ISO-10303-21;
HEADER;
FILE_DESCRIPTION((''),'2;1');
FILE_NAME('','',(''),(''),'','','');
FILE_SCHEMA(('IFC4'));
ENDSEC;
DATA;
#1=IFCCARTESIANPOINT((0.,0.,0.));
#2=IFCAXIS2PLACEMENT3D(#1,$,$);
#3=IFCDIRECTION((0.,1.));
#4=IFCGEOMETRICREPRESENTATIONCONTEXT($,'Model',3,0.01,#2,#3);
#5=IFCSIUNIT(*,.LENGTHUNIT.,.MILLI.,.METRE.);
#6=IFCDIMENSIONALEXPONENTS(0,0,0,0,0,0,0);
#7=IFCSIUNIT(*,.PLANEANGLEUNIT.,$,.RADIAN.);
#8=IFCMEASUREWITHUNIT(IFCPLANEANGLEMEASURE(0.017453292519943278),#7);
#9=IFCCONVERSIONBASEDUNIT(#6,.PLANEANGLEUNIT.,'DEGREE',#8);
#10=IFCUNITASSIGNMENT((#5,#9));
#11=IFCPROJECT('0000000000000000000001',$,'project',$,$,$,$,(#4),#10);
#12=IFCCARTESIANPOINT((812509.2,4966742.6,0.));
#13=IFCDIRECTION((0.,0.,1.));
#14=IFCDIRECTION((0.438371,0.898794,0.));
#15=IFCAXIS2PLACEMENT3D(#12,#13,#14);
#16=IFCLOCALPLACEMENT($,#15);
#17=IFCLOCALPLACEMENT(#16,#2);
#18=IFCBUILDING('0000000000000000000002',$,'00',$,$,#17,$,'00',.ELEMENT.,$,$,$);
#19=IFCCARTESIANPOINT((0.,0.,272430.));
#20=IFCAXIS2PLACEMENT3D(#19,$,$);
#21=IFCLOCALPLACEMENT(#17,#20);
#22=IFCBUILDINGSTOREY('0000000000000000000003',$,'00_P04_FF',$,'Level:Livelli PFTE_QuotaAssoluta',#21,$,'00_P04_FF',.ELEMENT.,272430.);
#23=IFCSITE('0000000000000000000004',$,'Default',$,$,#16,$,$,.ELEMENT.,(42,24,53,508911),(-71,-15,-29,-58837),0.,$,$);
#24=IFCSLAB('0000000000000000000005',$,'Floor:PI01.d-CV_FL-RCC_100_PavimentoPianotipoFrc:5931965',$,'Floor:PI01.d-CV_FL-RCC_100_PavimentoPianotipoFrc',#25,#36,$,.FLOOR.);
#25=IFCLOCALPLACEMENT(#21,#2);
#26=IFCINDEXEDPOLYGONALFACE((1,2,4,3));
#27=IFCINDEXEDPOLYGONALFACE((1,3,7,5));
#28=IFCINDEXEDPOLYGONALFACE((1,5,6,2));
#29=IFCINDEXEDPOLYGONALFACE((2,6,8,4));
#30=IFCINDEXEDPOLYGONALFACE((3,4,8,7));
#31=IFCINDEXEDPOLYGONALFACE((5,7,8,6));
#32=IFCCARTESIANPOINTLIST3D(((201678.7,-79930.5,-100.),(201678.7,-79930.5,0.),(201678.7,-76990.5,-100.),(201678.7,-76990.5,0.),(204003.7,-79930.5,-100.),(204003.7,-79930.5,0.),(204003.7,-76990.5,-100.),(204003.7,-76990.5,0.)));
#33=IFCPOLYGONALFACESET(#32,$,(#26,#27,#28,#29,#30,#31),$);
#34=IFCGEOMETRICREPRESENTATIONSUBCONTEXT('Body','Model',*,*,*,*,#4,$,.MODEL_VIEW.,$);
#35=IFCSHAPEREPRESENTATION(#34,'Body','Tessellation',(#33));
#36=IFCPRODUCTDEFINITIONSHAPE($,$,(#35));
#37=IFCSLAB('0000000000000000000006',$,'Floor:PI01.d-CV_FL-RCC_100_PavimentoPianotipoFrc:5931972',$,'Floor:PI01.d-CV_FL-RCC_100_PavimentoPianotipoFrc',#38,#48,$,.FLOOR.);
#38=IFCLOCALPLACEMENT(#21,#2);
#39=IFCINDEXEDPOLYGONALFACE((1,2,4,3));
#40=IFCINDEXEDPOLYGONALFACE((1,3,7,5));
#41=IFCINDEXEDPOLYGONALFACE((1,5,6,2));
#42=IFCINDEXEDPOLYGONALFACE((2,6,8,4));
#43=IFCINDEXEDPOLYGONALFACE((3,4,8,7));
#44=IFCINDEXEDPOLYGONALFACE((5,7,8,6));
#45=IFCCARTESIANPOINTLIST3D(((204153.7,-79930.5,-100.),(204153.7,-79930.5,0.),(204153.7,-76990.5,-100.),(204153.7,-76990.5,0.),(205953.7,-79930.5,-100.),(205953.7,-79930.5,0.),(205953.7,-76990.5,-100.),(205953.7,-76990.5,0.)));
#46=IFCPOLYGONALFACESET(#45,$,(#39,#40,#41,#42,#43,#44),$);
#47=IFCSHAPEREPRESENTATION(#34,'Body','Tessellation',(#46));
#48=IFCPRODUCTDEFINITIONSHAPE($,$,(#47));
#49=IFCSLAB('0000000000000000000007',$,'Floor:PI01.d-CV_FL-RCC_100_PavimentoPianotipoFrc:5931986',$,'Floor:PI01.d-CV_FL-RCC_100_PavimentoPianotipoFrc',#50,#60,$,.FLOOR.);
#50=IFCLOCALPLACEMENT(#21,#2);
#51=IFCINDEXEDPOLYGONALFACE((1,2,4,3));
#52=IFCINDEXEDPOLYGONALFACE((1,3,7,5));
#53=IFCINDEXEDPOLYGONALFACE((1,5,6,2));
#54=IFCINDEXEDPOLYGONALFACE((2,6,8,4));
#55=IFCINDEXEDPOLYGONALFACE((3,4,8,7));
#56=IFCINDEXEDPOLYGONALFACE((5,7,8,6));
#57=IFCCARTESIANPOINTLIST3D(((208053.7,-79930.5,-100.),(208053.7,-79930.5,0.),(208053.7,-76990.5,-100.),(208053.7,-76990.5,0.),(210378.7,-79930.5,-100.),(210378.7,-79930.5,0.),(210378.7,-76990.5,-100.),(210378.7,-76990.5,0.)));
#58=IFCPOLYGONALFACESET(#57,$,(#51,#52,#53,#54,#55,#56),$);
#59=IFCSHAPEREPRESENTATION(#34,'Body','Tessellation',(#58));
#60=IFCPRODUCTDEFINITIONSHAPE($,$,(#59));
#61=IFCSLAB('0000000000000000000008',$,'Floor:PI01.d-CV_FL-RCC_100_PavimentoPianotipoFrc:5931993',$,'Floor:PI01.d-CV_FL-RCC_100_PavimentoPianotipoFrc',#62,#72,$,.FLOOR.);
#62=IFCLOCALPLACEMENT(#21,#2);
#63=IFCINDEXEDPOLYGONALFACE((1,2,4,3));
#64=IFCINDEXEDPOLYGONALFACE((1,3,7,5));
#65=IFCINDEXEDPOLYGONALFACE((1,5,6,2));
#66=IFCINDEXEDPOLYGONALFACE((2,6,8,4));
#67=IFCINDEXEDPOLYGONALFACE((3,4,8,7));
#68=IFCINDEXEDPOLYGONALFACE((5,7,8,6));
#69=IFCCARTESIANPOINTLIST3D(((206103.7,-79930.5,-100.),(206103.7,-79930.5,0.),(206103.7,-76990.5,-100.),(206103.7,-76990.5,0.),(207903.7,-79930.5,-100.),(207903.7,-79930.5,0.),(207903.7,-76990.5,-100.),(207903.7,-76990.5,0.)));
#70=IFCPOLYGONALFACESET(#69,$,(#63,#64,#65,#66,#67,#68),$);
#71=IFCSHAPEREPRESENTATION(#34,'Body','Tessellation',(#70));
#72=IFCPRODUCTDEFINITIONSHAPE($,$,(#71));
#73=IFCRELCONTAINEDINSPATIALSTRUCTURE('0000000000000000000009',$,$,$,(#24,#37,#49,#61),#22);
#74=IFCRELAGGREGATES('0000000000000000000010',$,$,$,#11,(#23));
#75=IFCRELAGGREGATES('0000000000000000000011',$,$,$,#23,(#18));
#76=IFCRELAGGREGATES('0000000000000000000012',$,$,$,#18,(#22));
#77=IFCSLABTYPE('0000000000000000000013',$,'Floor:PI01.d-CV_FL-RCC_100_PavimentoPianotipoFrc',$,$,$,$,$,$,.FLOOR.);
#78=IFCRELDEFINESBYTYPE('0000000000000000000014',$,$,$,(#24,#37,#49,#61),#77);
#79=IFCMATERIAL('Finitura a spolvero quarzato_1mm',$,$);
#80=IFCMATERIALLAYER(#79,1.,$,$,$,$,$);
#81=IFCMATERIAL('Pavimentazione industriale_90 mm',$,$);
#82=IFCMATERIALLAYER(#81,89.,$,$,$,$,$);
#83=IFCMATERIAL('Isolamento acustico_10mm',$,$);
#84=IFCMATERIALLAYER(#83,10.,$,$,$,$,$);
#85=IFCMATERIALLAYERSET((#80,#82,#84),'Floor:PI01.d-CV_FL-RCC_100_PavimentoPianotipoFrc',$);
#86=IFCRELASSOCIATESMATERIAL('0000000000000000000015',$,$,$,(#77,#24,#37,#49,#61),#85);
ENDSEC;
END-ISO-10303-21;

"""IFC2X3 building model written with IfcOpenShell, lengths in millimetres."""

from ifc_helpers import new_model, entity, si_unit, converted_unit, direction, frame, frame_2d, origin, place, context, subcontext, project, spatial, rectangle, extrude, material, layer, layer_set, layer_usage, type_object, element, save


model = new_model("IFC2X3")

# Units and contexts
model_context = context("Model", 3, precision=0.01, world=origin(), true_north=direction((0.0, 1.0)))
body_context = subcontext(model_context, "Body", "Model", "MODEL_VIEW")
ifc_project = project(units=[si_unit("LENGTHUNIT", "METRE", prefix="MILLI"), converted_unit("PLANEANGLEUNIT", "DEGREE", entity("IfcPlaneAngleMeasure", 0.017453292519943278), si_unit("PLANEANGLEUNIT", "RADIAN"), dimensions=[0, 0, 0, 0, 0, 0, 0])], contexts=[model_context])

# Site, building, storey
site_placement = place(None, frame((812509.2, 4966742.6, 0.0), z_axis=(0.0, 0.0, 1.0), x_axis=(0.438371, 0.898794, 0.0)))
site = spatial("IfcSite", under=ifc_project, at=site_placement, Name="Default", CompositionType="ELEMENT", RefLatitude=(42, 24, 53, 508911), RefLongitude=(-71, -15, -29, -58837), RefElevation=0.0)
building_placement = place(site_placement, origin())
building = spatial("IfcBuilding", under=site, at=building_placement, Name="00", LongName="00", CompositionType="ELEMENT")
storey_placement = place(building_placement, frame((0.0, 0.0, 272430.0)))
storey = spatial("IfcBuildingStorey", under=building, at=storey_placement, Name="00_P04_FF", ObjectType="Level:Livelli PFTE_QuotaAssoluta", LongName="00_P04_FF", CompositionType="ELEMENT", Elevation=272430.0)

# Slabs
ifc_material_1 = material(Name="Isolamento acustico_10mm")
ifc_material_2 = material(Name="Finitura a spolvero quarzato_1mm")
ifc_layer_1 = layer(ifc_material_2, 1.0)
ifc_material_3 = material(Name="Pavimentazione industriale_90 mm")
ifc_layer_2 = layer(ifc_material_3, 89.0)
ifc_layer_3 = layer(ifc_material_1, 10.0)
ifc_layer_set_1 = layer_set([ifc_layer_1, ifc_layer_2, ifc_layer_3], Name="Floor:PI01.d-CV_FL-RCC_100_PavimentoPianotipoFrc")
ifc_layer_usage_1 = layer_usage(ifc_layer_set_1, "AXIS3", "POSITIVE", 0.0)
slab_type_1 = type_object("IfcSlabType", Name="Floor:PI01.d-CV_FL-RCC_100_PavimentoPianotipoFrc", PredefinedType="FLOOR", material=ifc_layer_set_1)
slab_1_placement = place(storey_placement, origin())
element("IfcSlab", 1, at=slab_1_placement, inside=storey, type_object=slab_type_1, material=ifc_layer_usage_1, Name="Floor:PI01.d-CV_FL-RCC_100_PavimentoPianotipoFrc:5931965", ObjectType="Floor:PI01.d-CV_FL-RCC_100_PavimentoPianotipoFrc", PredefinedType="FLOOR", context=body_context, shape_type="SweptSolid", body=[
    extrude(rectangle(XDim=2940.0, YDim=2325.0, at=frame_2d((0.0, 0.0), x_axis=(1.0, 0.0))), frame((202841.2, -78460.5, 0.0), z_axis=(0.0, 0.0, -1.0), x_axis=(0.0, 1.0, 0.0)), (0.0, 0.0, 1.0), 100.0),
])
ifc_layer_usage_2 = layer_usage(ifc_layer_set_1, "AXIS3", "POSITIVE", 0.0)
slab_2_placement = place(storey_placement, origin())
element("IfcSlab", 2, at=slab_2_placement, inside=storey, type_object=slab_type_1, material=ifc_layer_usage_2, Name="Floor:PI01.d-CV_FL-RCC_100_PavimentoPianotipoFrc:5931972", ObjectType="Floor:PI01.d-CV_FL-RCC_100_PavimentoPianotipoFrc", PredefinedType="FLOOR", context=body_context, shape_type="SweptSolid", body=[
    extrude(rectangle(XDim=2940.0, YDim=1800.0, at=frame_2d((0.0, 0.0), x_axis=(1.0, 0.0))), frame((205053.7, -78460.5, 0.0), z_axis=(0.0, 0.0, -1.0), x_axis=(0.0, 1.0, 0.0)), (0.0, 0.0, 1.0), 100.0),
])
ifc_layer_usage_3 = layer_usage(ifc_layer_set_1, "AXIS3", "POSITIVE", 0.0)
slab_3_placement = place(storey_placement, origin())
element("IfcSlab", 3, at=slab_3_placement, inside=storey, type_object=slab_type_1, material=ifc_layer_usage_3, Name="Floor:PI01.d-CV_FL-RCC_100_PavimentoPianotipoFrc:5931986", ObjectType="Floor:PI01.d-CV_FL-RCC_100_PavimentoPianotipoFrc", PredefinedType="FLOOR", context=body_context, shape_type="SweptSolid", body=[
    extrude(rectangle(XDim=2940.0, YDim=2325.0, at=frame_2d((0.0, 0.0), x_axis=(1.0, 0.0))), frame((209216.2, -78460.5, 0.0), z_axis=(0.0, 0.0, -1.0), x_axis=(0.0, 1.0, 0.0)), (0.0, 0.0, 1.0), 100.0),
])
ifc_layer_usage_4 = layer_usage(ifc_layer_set_1, "AXIS3", "POSITIVE", 0.0)
slab_4_placement = place(storey_placement, origin())
element("IfcSlab", 4, at=slab_4_placement, inside=storey, type_object=slab_type_1, material=ifc_layer_usage_4, Name="Floor:PI01.d-CV_FL-RCC_100_PavimentoPianotipoFrc:5931993", ObjectType="Floor:PI01.d-CV_FL-RCC_100_PavimentoPianotipoFrc", PredefinedType="FLOOR", context=body_context, shape_type="SweptSolid", body=[
    extrude(rectangle(XDim=2940.0, YDim=1800.0, at=frame_2d((0.0, 0.0), x_axis=(1.0, 0.0))), frame((207003.7, -78460.5, 0.0), z_axis=(0.0, 0.0, -1.0), x_axis=(0.0, 1.0, 0.0)), (0.0, 0.0, 1.0), 100.0),
])

save(model, "model.ifc")
